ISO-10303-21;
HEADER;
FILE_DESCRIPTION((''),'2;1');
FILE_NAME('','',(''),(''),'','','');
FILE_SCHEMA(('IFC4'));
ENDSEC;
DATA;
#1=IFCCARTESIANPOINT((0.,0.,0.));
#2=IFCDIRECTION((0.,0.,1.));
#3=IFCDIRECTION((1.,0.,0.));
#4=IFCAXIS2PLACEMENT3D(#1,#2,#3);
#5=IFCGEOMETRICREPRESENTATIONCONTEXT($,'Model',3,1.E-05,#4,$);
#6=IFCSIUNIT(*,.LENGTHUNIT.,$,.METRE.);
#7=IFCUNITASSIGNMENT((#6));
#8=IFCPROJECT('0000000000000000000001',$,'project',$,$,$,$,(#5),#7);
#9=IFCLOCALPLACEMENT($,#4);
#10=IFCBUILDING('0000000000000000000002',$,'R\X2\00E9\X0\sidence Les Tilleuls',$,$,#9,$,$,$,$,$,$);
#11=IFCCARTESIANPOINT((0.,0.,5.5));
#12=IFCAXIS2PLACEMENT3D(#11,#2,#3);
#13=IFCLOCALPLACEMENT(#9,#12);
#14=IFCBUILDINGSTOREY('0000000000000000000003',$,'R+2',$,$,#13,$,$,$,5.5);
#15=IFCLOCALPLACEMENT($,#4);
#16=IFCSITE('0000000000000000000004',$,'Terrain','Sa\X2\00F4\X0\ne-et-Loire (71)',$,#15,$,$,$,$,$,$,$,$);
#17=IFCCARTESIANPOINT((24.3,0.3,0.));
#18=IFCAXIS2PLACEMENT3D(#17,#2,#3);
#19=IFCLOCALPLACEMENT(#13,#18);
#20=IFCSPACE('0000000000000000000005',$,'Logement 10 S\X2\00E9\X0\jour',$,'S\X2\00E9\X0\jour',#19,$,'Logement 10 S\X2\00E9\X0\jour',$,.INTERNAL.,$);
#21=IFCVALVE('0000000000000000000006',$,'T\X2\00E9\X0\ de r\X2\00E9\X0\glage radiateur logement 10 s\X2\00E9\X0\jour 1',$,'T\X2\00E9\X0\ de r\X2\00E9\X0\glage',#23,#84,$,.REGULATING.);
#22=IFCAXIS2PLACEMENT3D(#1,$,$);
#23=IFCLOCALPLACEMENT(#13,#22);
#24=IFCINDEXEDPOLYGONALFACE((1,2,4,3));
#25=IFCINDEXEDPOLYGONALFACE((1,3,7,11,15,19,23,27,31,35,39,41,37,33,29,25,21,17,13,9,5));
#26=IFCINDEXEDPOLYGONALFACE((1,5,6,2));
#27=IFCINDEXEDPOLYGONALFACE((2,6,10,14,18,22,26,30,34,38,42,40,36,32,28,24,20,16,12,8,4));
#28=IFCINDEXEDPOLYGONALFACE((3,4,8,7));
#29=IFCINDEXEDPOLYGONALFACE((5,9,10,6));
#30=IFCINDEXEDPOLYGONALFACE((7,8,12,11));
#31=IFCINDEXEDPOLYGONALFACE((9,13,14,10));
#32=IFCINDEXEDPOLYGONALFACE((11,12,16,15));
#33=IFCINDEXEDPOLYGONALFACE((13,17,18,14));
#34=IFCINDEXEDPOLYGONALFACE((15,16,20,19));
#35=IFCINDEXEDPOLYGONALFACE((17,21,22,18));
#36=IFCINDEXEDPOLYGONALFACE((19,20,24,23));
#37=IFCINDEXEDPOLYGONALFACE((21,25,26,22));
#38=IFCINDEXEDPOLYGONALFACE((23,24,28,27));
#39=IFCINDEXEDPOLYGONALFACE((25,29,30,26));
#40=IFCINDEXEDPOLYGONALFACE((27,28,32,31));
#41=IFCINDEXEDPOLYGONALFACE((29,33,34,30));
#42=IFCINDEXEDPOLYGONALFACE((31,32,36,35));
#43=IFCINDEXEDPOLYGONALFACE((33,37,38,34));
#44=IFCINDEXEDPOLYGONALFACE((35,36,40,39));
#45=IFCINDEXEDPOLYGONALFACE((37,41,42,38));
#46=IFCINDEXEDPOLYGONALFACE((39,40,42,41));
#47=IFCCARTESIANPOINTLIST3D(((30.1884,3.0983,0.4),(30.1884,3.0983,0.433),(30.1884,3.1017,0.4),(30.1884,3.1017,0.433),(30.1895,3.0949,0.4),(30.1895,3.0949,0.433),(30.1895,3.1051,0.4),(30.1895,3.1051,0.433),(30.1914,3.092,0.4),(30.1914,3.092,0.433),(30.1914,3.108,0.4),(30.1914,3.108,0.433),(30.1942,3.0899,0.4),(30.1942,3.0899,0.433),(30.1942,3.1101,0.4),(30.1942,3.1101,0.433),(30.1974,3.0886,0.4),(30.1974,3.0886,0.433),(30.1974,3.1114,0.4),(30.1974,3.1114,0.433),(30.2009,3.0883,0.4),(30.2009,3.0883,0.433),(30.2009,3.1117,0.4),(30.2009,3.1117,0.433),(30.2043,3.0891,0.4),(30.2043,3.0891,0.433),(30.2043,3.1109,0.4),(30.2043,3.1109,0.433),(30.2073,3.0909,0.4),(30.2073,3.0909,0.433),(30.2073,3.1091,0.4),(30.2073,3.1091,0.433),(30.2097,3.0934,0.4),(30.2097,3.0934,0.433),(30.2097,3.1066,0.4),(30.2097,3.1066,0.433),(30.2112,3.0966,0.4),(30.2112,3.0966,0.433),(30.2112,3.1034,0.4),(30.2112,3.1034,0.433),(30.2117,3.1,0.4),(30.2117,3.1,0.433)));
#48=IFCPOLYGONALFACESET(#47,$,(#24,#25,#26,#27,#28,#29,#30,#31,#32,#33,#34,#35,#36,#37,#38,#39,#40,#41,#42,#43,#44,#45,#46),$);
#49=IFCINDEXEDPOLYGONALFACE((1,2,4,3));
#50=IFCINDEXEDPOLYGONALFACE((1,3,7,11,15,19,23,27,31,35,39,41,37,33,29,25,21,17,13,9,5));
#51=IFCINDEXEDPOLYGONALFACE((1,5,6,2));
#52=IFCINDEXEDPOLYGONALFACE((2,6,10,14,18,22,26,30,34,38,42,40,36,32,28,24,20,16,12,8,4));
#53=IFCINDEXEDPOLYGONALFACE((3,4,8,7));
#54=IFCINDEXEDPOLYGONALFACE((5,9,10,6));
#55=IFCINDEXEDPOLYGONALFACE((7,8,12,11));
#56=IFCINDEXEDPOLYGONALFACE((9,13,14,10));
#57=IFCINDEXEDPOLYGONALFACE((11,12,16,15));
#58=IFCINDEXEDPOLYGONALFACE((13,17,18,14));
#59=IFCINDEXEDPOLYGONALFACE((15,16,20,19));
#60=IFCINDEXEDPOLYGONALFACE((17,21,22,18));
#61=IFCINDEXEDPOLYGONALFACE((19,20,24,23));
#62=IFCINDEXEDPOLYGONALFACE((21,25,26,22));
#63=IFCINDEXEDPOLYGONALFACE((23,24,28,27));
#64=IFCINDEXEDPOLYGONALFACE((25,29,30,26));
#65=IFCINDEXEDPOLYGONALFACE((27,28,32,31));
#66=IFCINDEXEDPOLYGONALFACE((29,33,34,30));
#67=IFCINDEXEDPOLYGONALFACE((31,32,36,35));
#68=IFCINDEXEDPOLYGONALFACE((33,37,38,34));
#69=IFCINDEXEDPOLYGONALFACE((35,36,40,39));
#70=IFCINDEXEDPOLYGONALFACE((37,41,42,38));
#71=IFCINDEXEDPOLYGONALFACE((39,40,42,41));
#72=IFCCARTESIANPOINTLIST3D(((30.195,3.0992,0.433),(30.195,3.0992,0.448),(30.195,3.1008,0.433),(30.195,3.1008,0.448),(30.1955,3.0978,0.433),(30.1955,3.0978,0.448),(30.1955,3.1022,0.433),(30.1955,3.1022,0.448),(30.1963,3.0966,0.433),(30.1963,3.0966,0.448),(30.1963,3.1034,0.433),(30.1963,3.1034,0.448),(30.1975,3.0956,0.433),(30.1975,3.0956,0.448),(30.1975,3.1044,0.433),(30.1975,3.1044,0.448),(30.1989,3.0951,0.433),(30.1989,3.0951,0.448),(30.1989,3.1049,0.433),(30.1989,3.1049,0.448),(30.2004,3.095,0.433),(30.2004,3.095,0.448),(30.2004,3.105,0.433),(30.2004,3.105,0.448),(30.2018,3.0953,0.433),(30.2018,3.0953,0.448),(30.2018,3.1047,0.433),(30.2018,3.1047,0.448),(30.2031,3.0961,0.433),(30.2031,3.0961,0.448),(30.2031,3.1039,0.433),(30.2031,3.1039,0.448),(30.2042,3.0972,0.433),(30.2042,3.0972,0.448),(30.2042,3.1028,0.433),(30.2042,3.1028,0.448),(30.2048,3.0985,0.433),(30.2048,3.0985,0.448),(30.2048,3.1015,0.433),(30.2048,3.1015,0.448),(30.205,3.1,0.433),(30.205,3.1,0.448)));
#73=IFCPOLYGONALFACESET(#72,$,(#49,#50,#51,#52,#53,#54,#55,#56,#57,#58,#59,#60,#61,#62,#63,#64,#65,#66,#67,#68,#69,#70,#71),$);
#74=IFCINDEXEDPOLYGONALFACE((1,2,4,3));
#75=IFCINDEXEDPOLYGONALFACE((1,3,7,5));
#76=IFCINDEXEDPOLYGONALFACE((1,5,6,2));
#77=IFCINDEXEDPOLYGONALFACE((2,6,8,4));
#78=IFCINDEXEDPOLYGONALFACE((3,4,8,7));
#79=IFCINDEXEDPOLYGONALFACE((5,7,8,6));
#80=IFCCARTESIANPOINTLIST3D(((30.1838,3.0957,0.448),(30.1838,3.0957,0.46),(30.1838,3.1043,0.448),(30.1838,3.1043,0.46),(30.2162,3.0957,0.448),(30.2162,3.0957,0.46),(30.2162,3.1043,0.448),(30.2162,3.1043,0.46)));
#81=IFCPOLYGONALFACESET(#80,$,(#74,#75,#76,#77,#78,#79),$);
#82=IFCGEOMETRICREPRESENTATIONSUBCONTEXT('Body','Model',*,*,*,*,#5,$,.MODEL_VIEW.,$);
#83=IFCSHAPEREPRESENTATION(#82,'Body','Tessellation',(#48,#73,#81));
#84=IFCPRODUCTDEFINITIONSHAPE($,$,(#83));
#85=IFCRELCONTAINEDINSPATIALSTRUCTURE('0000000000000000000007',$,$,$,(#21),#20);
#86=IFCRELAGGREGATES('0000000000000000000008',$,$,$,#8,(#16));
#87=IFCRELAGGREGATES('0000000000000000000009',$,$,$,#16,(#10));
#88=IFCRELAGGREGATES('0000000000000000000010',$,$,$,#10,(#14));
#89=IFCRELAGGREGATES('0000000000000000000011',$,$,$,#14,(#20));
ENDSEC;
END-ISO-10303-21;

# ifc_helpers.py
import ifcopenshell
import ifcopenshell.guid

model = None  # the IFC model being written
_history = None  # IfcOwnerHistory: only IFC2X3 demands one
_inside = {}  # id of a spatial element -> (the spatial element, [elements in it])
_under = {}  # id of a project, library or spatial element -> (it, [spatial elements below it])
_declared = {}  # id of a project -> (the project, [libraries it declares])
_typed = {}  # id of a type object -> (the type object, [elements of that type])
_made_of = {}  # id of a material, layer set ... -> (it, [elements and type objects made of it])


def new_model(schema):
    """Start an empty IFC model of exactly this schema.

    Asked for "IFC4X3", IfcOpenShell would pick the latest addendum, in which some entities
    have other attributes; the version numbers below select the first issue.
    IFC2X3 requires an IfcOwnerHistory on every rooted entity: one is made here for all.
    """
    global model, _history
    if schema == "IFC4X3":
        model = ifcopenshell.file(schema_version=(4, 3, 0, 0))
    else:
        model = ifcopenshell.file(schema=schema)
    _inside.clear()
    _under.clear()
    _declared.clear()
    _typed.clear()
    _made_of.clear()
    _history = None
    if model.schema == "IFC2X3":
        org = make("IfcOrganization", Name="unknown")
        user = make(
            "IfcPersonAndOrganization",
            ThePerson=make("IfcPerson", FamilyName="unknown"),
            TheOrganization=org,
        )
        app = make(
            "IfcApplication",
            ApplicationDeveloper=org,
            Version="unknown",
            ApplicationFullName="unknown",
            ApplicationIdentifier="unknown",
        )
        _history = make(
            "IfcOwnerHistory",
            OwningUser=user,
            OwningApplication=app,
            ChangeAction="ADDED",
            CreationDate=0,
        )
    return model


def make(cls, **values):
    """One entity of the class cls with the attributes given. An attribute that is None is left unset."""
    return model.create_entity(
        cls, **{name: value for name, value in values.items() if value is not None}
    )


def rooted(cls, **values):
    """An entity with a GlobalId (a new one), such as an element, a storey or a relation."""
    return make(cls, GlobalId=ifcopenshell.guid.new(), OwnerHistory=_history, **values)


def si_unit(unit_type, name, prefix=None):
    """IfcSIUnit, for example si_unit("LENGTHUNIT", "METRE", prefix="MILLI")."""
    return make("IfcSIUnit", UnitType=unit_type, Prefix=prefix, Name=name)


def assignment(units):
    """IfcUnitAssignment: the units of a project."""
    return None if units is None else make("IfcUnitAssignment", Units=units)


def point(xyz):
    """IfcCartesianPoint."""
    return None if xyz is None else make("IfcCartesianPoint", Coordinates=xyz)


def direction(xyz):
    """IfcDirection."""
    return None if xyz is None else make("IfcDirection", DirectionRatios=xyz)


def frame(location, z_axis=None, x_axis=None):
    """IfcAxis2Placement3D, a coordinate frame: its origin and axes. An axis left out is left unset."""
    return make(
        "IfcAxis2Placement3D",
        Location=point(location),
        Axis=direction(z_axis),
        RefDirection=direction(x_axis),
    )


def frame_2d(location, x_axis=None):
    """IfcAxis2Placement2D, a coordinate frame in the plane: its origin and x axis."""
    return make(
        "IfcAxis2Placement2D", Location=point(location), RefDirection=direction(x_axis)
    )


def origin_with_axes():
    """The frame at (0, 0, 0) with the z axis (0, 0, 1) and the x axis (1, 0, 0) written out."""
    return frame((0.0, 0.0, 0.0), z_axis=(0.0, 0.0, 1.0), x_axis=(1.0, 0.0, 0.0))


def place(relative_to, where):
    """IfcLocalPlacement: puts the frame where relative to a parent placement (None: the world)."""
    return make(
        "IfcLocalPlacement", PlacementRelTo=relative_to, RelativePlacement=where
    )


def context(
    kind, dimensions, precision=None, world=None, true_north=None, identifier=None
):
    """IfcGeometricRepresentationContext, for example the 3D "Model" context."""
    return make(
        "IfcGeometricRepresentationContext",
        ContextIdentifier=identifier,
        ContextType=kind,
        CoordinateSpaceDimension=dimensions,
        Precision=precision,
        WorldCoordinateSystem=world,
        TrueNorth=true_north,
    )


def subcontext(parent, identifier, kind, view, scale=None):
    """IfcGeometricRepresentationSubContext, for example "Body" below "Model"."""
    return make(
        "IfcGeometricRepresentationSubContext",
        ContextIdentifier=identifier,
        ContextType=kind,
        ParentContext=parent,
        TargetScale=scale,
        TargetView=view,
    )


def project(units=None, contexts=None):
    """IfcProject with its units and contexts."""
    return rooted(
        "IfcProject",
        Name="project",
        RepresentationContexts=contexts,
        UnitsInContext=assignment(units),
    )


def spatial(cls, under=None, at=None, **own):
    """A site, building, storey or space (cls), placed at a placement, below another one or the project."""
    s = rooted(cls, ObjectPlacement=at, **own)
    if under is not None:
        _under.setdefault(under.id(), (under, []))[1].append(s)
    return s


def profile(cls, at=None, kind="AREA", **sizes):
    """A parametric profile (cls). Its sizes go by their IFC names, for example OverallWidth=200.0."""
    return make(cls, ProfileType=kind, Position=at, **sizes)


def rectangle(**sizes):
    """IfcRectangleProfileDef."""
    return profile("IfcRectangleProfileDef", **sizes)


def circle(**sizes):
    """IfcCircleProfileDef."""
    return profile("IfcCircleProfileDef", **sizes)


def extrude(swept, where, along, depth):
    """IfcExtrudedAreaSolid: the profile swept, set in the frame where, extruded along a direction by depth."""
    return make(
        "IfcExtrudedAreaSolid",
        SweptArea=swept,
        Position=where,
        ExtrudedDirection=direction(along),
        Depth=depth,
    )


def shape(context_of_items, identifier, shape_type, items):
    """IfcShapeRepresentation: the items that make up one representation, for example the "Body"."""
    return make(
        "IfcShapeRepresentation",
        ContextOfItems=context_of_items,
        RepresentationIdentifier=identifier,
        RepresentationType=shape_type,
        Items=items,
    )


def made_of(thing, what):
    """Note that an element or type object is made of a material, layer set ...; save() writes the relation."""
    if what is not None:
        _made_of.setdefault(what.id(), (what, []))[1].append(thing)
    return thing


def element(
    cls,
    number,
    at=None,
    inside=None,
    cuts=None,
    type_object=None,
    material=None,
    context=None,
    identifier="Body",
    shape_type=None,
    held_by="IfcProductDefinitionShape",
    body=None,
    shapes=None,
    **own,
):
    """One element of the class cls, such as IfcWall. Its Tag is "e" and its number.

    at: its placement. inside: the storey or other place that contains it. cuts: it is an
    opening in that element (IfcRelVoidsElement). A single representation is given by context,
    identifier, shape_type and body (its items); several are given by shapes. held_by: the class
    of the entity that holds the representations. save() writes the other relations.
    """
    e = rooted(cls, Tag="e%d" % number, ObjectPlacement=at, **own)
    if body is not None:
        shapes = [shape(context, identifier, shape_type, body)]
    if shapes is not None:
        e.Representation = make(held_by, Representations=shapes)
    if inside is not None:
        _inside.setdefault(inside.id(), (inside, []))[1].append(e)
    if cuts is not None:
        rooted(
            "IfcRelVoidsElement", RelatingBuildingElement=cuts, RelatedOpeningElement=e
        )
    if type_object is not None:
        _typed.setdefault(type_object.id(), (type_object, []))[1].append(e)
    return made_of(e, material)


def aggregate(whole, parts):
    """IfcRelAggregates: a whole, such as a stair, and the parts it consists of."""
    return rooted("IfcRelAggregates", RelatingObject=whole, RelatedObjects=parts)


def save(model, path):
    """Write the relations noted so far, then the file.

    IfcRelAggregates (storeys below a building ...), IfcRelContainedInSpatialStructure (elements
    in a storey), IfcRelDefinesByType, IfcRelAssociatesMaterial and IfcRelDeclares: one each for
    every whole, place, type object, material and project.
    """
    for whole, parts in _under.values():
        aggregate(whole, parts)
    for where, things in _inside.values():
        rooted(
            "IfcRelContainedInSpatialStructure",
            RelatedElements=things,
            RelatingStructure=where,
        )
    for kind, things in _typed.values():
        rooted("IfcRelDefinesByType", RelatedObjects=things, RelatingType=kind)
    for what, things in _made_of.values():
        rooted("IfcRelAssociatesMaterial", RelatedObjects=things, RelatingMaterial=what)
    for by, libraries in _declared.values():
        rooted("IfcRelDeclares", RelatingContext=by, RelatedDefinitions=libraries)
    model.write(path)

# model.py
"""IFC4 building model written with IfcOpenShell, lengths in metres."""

from ifc_helpers import new_model, si_unit, frame, frame_2d, origin_with_axes, place, context, subcontext, project, spatial, rectangle, circle, extrude, element, save


model = new_model("IFC4")

# Units and contexts
model_context = context("Model", 3, precision=1e-05, world=origin_with_axes())
body_context = subcontext(model_context, "Body", "Model", "MODEL_VIEW")
ifc_project = project(units=[si_unit("LENGTHUNIT", "METRE")], contexts=[model_context])

# Site, building, storey
site_placement = place(None, origin_with_axes())
site = spatial("IfcSite", under=ifc_project, at=site_placement, Name="Terrain", Description="Saône-et-Loire (71)")
building_placement = place(None, origin_with_axes())
building = spatial("IfcBuilding", under=site, at=building_placement, Name="Résidence Les Tilleuls")
storey_placement = place(building_placement, frame((0.0, 0.0, 5.5), z_axis=(0.0, 0.0, 1.0), x_axis=(1.0, 0.0, 0.0)))
storey = spatial("IfcBuildingStorey", under=building, at=storey_placement, Name="R+2", Elevation=5.5)

# Shared definitions
space_placement = place(storey_placement, frame((24.3, 0.3, 0.0), z_axis=(0.0, 0.0, 1.0), x_axis=(1.0, 0.0, 0.0)))
space = spatial("IfcSpace", under=storey, at=space_placement, Name="Logement 10 Séjour", ObjectType="Séjour", LongName="Logement 10 Séjour", PredefinedType="INTERNAL")

# Valve
valve_1_placement = place(space_placement, frame((5.9, 2.8, 0.4), z_axis=(0.0, 0.0, 1.0), x_axis=(1.0, 0.0, 0.0)))
element("IfcValve", 1, at=valve_1_placement, inside=space, Name="Té de réglage radiateur logement 10 séjour 1", ObjectType="Té de réglage", PredefinedType="REGULATING", context=body_context, shape_type="SweptSolid", body=[
    extrude(circle(Radius=0.0117), origin_with_axes(), (0.0, 0.0, 1.0), 0.033),
    extrude(circle(Radius=0.005), frame((0.0, 0.0, 0.033), z_axis=(0.0, 0.0, 1.0), x_axis=(1.0, 0.0, 0.0)), (0.0, 0.0, 1.0), 0.015),
    extrude(rectangle(XDim=0.0324, YDim=0.0086, at=frame_2d((0.0162, 0.0043))), frame((-0.0162, -0.0043, 0.048), z_axis=(0.0, 0.0, 1.0), x_axis=(1.0, 0.0, 0.0)), (0.0, 0.0, 1.0), 0.012),
])

save(model, "model.ifc")
